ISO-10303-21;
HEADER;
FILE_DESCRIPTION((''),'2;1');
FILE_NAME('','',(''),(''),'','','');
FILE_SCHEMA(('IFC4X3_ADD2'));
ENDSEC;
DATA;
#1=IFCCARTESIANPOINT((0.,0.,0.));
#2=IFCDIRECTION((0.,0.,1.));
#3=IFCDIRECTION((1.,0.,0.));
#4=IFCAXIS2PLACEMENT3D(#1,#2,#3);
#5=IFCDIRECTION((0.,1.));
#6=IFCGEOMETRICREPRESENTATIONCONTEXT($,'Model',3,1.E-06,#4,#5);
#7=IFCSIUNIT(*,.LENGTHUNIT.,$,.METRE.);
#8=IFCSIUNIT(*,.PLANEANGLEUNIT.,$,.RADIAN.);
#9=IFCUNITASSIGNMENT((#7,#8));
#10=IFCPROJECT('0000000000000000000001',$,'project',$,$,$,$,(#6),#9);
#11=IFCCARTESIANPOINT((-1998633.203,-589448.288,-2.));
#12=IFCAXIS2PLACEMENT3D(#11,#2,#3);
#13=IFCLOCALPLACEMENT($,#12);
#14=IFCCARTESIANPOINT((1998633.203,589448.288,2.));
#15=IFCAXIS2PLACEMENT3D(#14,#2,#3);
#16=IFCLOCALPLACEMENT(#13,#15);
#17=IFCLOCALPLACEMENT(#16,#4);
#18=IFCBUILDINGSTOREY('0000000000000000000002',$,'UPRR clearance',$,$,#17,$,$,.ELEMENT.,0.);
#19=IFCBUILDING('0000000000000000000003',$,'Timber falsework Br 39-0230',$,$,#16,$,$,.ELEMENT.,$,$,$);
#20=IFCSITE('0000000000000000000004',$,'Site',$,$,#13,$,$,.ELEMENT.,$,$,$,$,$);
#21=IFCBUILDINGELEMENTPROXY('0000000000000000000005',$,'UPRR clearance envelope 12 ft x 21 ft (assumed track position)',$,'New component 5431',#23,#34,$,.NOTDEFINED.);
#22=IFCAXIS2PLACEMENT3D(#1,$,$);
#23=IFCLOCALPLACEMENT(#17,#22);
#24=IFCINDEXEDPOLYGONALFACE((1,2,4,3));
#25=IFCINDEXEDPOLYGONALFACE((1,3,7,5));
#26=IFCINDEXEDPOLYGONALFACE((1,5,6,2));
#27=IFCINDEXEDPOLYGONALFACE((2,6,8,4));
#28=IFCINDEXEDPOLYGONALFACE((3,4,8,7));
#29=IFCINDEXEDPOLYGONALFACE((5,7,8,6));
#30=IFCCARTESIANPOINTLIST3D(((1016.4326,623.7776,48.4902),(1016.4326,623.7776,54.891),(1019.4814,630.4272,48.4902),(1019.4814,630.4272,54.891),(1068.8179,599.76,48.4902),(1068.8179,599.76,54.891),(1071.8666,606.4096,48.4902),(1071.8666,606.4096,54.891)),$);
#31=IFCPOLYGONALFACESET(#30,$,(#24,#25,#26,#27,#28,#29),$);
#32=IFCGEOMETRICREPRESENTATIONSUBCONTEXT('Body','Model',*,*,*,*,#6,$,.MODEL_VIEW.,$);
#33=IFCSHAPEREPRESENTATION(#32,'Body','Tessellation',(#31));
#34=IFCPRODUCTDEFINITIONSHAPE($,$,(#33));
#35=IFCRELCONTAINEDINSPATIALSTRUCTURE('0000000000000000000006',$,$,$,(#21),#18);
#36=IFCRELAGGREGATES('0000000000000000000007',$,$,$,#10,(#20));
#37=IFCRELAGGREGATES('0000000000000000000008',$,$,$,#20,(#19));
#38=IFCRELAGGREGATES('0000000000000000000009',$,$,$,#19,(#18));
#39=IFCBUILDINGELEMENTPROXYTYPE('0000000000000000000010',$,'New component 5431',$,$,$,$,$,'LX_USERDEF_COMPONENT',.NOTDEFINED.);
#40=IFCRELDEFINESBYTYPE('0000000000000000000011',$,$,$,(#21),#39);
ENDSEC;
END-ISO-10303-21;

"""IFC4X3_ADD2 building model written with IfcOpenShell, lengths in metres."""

from ifc_helpers import new_model, si_unit, direction, frame, frame_2d, origin_with_axes, place, context, subcontext, project, spatial, rectangle, extrude, type_object, element, save


model = new_model("IFC4X3_ADD2")

# Units and contexts
model_context = context("Model", 3, precision=1e-06, world=origin_with_axes(), true_north=direction((0.0, 1.0)))
body_context = subcontext(model_context, "Body", "Model", "MODEL_VIEW")
ifc_project = project(units=[si_unit("LENGTHUNIT", "METRE"), si_unit("PLANEANGLEUNIT", "RADIAN")], contexts=[model_context])

# Site, building, storey
site_placement = place(None, frame((-1998633.203, -589448.288, -2.0), z_axis=(0.0, 0.0, 1.0), x_axis=(1.0, 0.0, 0.0)))
site = spatial("IfcSite", under=ifc_project, at=site_placement, Name="Site", CompositionType="ELEMENT")
building_placement = place(site_placement, frame((1998633.203, 589448.288, 2.0), z_axis=(0.0, 0.0, 1.0), x_axis=(1.0, 0.0, 0.0)))
building = spatial("IfcBuilding", under=site, at=building_placement, Name="Timber falsework Br 39-0230", CompositionType="ELEMENT")
storey_placement = place(building_placement, origin_with_axes())
storey = spatial("IfcBuildingStorey", under=building, at=storey_placement, Name="UPRR clearance", CompositionType="ELEMENT", Elevation=0.0)

# Building element proxy
building_element_proxy_type = type_object("IfcBuildingElementProxyType", Name="New component 5431", ElementType="LX_USERDEF_COMPONENT", PredefinedType="NOTDEFINED")
placement_1 = place(site_placement, origin_with_axes())
placement_2 = place(placement_1, origin_with_axes())
proxy_placement = place(placement_2, frame((1999651.16, 590075.3904, 50.4902), z_axis=(0.909014, -0.416765, 0.0), x_axis=(0.416765, 0.909014, 0.0)))
element("IfcBuildingElementProxy", 1, at=proxy_placement, inside=storey, type_object=building_element_proxy_type, Name="UPRR clearance envelope 12 ft x 21 ft (assumed track position)", ObjectType="New component 5431", PredefinedType="NOTDEFINED", context=body_context, shape_type="SweptSolid", body=[
    extrude(rectangle(XDim=7.3152, YDim=6.4008, at=frame_2d((3.6576, 3.2004), x_axis=(1.0, 0.0))), frame((-3.6576, 0.0, 0.0), z_axis=(0.0, 0.0, 1.0), x_axis=(1.0, 0.0, 0.0)), (0.0, 0.0, 1.0), 57.6286),
])

save(model, "model.ifc")
